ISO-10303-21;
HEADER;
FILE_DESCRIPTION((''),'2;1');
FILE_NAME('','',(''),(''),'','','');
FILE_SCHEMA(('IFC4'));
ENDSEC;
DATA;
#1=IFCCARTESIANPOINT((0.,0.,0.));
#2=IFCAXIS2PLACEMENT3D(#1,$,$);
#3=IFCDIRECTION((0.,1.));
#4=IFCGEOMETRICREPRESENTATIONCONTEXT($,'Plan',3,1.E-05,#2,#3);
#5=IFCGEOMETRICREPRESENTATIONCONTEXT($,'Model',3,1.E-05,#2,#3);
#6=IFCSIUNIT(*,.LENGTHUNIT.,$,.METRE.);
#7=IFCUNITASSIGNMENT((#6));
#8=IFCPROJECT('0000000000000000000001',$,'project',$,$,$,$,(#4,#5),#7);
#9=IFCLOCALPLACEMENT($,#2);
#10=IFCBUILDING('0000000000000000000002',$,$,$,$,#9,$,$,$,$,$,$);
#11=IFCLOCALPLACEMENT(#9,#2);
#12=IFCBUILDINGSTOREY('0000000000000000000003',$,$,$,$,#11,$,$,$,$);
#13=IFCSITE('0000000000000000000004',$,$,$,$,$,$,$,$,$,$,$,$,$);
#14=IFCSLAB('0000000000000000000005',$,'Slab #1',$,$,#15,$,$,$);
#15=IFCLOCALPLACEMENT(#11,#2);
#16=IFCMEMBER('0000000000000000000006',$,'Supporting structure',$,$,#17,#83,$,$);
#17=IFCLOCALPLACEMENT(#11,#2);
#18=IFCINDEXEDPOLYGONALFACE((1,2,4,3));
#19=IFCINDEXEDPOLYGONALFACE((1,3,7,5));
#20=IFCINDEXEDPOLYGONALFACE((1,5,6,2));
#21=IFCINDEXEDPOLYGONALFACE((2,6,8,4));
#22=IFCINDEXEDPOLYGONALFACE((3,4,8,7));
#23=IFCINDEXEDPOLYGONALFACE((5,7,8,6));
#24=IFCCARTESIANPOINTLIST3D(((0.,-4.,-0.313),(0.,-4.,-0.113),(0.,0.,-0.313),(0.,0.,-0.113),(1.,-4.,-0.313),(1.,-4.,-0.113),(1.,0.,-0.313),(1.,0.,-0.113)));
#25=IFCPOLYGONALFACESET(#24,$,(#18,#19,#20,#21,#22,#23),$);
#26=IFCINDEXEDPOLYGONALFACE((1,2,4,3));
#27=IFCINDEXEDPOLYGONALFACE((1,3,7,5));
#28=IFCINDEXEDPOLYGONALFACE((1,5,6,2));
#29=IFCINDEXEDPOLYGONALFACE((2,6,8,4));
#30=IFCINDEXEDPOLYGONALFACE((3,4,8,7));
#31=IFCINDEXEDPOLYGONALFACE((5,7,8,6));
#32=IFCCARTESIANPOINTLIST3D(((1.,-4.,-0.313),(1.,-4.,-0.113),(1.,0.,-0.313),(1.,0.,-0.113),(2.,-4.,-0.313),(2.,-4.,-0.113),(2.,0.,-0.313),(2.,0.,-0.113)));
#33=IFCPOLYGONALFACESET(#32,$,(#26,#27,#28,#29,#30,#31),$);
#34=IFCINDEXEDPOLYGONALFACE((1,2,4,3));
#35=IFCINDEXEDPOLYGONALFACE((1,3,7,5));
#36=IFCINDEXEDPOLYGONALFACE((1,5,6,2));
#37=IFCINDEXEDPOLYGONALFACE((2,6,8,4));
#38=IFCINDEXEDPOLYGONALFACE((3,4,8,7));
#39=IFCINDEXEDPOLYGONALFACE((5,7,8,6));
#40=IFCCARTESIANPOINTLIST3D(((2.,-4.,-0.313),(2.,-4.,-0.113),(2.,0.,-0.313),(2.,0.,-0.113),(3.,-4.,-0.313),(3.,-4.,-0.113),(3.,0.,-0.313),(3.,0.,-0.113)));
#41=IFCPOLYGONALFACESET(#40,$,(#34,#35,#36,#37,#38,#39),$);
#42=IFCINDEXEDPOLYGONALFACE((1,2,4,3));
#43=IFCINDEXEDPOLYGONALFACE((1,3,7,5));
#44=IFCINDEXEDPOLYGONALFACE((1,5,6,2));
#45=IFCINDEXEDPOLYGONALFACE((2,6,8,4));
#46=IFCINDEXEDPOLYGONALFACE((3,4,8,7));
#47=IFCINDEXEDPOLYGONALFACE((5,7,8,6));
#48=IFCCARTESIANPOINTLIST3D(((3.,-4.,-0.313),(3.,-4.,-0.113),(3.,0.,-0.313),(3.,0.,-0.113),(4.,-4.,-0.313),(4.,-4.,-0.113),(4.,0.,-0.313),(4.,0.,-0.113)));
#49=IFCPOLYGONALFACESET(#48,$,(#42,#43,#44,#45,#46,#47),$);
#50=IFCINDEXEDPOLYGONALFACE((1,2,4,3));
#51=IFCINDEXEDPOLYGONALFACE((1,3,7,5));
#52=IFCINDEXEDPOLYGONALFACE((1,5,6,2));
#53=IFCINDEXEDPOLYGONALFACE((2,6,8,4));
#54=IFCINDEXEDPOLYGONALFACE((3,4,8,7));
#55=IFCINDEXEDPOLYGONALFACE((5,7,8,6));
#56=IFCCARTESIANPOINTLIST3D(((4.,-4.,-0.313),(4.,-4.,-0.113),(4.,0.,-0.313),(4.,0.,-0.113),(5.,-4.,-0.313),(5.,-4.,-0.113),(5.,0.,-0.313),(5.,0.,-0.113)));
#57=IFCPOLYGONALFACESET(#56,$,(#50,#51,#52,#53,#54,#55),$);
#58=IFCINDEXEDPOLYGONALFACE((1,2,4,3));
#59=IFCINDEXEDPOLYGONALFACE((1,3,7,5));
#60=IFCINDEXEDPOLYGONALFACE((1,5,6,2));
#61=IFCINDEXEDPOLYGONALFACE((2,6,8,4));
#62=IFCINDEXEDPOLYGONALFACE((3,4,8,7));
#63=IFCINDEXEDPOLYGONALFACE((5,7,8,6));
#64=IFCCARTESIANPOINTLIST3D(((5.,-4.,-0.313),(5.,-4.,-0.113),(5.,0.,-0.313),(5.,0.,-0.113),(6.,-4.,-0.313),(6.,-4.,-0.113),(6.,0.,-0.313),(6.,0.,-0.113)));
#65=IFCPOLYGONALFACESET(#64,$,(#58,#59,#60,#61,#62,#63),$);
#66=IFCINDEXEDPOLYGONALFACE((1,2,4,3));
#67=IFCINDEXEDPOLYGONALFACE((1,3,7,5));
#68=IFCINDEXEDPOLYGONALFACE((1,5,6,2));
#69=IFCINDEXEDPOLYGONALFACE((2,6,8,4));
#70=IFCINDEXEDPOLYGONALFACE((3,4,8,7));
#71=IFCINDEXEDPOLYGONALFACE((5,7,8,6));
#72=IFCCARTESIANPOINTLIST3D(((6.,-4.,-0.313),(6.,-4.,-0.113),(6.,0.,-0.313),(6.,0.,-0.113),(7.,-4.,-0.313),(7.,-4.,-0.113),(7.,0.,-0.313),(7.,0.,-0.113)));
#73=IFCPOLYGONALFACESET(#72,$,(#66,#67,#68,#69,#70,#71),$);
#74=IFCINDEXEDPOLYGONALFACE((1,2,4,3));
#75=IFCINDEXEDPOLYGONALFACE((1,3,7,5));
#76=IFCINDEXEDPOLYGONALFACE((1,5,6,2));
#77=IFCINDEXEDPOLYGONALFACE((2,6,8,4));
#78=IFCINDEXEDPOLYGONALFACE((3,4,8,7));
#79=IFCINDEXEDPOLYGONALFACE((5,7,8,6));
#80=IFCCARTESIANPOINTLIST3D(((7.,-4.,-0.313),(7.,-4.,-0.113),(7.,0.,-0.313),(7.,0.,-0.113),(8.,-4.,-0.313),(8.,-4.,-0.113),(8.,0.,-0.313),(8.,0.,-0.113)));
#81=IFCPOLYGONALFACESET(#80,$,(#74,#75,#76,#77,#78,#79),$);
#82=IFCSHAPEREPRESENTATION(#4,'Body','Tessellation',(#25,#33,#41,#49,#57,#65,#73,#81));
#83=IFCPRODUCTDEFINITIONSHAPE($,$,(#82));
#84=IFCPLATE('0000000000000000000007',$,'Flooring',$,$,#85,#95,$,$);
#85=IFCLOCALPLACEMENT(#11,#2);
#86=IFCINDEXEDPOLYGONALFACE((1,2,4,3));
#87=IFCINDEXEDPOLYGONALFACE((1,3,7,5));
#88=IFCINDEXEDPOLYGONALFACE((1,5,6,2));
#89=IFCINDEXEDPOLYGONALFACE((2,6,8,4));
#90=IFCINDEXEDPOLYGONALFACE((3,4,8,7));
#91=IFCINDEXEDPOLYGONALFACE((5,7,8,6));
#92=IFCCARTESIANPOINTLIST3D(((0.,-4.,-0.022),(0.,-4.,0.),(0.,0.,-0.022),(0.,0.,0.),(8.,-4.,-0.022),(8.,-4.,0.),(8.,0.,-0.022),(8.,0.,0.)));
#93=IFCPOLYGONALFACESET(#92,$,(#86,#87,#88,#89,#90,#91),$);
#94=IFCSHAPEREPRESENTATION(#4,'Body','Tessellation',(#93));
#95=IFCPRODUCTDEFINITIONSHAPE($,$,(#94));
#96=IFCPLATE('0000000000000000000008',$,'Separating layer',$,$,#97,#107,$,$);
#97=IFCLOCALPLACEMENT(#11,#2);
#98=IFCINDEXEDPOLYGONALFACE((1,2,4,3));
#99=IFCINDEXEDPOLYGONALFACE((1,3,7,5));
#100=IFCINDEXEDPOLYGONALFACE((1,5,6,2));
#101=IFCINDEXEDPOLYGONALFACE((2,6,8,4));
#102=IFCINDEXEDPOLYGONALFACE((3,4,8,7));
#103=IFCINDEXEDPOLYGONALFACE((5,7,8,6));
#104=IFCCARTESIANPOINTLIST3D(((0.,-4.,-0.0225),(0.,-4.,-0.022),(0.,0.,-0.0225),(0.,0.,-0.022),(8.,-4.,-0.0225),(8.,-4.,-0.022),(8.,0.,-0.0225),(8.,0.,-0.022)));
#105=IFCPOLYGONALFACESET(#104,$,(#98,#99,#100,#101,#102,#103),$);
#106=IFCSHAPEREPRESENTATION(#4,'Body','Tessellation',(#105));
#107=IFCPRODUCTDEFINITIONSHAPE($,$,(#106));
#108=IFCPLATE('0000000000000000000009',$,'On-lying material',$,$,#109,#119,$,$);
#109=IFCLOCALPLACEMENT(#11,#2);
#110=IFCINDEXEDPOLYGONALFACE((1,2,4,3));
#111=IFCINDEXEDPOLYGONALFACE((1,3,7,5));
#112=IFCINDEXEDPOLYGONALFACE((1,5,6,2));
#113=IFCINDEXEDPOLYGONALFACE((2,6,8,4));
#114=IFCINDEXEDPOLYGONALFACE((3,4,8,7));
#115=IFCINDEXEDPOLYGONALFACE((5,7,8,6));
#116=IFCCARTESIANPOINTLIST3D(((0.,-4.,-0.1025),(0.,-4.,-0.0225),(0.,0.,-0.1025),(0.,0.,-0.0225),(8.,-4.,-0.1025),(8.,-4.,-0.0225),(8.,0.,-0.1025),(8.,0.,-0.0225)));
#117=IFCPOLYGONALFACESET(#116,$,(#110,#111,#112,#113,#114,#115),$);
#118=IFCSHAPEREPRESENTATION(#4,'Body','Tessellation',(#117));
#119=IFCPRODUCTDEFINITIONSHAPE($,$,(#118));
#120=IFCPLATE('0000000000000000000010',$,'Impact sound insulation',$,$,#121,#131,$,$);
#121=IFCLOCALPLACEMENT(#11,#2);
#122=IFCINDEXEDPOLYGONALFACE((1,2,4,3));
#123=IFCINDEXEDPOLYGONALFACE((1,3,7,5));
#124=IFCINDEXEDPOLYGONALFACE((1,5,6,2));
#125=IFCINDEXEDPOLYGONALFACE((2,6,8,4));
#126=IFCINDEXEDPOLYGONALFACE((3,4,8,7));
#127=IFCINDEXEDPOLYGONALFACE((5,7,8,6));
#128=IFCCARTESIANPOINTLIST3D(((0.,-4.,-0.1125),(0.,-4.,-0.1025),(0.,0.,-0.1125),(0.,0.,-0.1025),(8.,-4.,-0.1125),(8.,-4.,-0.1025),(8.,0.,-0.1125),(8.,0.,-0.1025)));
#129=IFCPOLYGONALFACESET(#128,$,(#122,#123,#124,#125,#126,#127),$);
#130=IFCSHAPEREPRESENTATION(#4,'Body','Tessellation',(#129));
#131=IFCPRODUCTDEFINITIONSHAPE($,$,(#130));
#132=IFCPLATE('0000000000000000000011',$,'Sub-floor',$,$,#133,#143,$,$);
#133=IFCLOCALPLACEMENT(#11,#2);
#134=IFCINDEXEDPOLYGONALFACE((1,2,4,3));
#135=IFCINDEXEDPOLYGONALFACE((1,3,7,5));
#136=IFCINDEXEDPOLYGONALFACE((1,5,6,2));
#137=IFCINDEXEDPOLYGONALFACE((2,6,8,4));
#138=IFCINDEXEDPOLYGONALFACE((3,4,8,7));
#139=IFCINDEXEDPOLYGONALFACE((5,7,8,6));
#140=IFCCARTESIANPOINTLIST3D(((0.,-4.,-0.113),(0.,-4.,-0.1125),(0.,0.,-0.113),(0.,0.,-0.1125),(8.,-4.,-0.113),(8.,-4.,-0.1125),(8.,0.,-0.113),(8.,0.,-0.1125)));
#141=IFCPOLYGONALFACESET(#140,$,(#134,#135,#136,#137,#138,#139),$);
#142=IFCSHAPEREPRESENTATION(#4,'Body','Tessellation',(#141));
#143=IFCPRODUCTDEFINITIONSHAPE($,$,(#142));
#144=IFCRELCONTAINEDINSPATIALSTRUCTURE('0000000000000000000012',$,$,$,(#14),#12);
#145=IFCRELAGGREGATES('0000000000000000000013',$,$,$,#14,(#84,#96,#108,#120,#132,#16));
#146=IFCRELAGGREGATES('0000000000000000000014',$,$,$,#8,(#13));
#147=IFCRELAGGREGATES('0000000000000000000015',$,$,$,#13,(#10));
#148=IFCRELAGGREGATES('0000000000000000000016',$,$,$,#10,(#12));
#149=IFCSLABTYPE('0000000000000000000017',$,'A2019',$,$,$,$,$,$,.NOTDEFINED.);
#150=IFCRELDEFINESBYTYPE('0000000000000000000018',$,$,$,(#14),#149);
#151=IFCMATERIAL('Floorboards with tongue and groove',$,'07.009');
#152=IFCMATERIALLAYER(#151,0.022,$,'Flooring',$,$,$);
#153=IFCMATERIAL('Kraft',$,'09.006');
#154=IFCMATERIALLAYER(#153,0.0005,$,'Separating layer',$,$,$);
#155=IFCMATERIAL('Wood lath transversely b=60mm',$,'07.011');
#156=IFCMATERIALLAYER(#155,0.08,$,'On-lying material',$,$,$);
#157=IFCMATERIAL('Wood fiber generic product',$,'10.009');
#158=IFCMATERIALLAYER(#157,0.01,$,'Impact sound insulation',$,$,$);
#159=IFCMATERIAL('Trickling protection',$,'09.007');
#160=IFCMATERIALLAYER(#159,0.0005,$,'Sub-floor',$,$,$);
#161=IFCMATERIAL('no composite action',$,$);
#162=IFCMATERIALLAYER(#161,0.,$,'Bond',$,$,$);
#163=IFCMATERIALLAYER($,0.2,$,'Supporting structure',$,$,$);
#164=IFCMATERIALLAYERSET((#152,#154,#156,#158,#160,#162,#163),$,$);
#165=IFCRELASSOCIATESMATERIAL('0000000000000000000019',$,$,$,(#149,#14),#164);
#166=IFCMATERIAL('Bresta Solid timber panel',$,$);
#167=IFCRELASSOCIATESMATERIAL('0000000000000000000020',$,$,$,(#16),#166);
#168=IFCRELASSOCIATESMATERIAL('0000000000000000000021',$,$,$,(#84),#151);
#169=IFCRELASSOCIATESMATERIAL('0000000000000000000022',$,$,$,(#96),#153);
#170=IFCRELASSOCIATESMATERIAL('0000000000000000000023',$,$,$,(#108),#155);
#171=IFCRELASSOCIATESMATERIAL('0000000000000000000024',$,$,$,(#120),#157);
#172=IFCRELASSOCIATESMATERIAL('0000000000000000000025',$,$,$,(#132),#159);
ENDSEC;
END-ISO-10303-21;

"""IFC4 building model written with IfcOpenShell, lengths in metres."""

from ifc_helpers import new_model, si_unit, direction, frame, frame_2d, origin, origin_with_axes, place, context, project, spatial, rectangle, extrude, material, layer, layer_set, type_object, element, aggregate, save


model = new_model("IFC4")

# Units and contexts
plan_context = context("Plan", 3, precision=1e-05, world=origin(), true_north=direction((0.0, 1.0)))
model_context = context("Model", 3, precision=1e-05, world=origin(), true_north=direction((0.0, 1.0)))
ifc_project = project(units=[si_unit("LENGTHUNIT", "METRE")], contexts=[plan_context, model_context])

# Site, building, storey
site = spatial("IfcSite", under=ifc_project)
building_placement = place(None, origin())
building = spatial("IfcBuilding", under=site, at=building_placement)
storey_placement = place(building_placement, origin())
storey = spatial("IfcBuildingStorey", under=building, at=storey_placement)

# Slab, member, plates
ifc_material_1 = material(Name="Floorboards with tongue and groove", Category="07.009")
ifc_layer_1 = layer(ifc_material_1, 0.022, Name="Flooring")
ifc_material_2 = material(Name="Kraft", Category="09.006")
ifc_layer_2 = layer(ifc_material_2, 0.0005, Name="Separating layer")
ifc_material_3 = material(Name="Wood lath transversely b=60mm", Category="07.011")
ifc_layer_3 = layer(ifc_material_3, 0.08, Name="On-lying material")
ifc_material_4 = material(Name="Wood fiber generic product", Category="10.009")
ifc_layer_4 = layer(ifc_material_4, 0.01, Name="Impact sound insulation")
ifc_material_5 = material(Name="Trickling protection", Category="09.007")
ifc_layer_5 = layer(ifc_material_5, 0.0005, Name="Sub-floor")
ifc_material_6 = material(Name="no composite action")
ifc_layer_6 = layer(ifc_material_6, 0.0, Name="Bond")
ifc_layer_7 = layer(None, 0.2, Name="Supporting structure")
ifc_layer_set = layer_set([ifc_layer_1, ifc_layer_2, ifc_layer_3, ifc_layer_4, ifc_layer_5, ifc_layer_6, ifc_layer_7])
slab_type = type_object("IfcSlabType", Name="A2019", PredefinedType="NOTDEFINED", material=ifc_layer_set)
slab_placement = place(None, frame((0.0, 0.0, 0.0), z_axis=(0.0, 0.0, -1.0), x_axis=(1.0, 0.0, 0.0)))
slab = element("IfcSlab", 1, at=slab_placement, inside=storey, type_object=slab_type, material=ifc_layer_set, Name="Slab #1")
ifc_material_7 = material(Name="Bresta Solid timber panel")
member_placement = place(slab_placement, origin())
member = element("IfcMember", 2, at=member_placement, material=ifc_material_7, Name="Supporting structure", context=plan_context, shape_type="SweptSolid", body=[
    extrude(rectangle(XDim=1.0, YDim=0.2, at=frame_2d((0.5, 0.1), x_axis=(1.0, 0.0))), frame((0.0, 4.0, 0.113), z_axis=(0.0, -1.0, 0.0), x_axis=(1.0, 0.0, 0.0)), (0.0, 0.0, 1.0), 4.0),
    extrude(rectangle(XDim=1.0, YDim=0.2, at=frame_2d((0.5, 0.1), x_axis=(1.0, 0.0))), frame((1.0, 4.0, 0.113), z_axis=(0.0, -1.0, 0.0), x_axis=(1.0, 0.0, 0.0)), (0.0, 0.0, 1.0), 4.0),
    extrude(rectangle(XDim=1.0, YDim=0.2, at=frame_2d((0.5, 0.1), x_axis=(1.0, 0.0))), frame((2.0, 4.0, 0.113), z_axis=(0.0, -1.0, 0.0), x_axis=(1.0, 0.0, 0.0)), (0.0, 0.0, 1.0), 4.0),
    extrude(rectangle(XDim=1.0, YDim=0.2, at=frame_2d((0.5, 0.1), x_axis=(1.0, 0.0))), frame((3.0, 4.0, 0.113), z_axis=(0.0, -1.0, 0.0), x_axis=(1.0, 0.0, 0.0)), (0.0, 0.0, 1.0), 4.0),
    extrude(rectangle(XDim=1.0, YDim=0.2, at=frame_2d((0.5, 0.1), x_axis=(1.0, 0.0))), frame((4.0, 4.0, 0.113), z_axis=(0.0, -1.0, 0.0), x_axis=(1.0, 0.0, 0.0)), (0.0, 0.0, 1.0), 4.0),
    extrude(rectangle(XDim=1.0, YDim=0.2, at=frame_2d((0.5, 0.1), x_axis=(1.0, 0.0))), frame((5.0, 4.0, 0.113), z_axis=(0.0, -1.0, 0.0), x_axis=(1.0, 0.0, 0.0)), (0.0, 0.0, 1.0), 4.0),
    extrude(rectangle(XDim=1.0, YDim=0.2, at=frame_2d((0.5, 0.1), x_axis=(1.0, 0.0))), frame((6.0, 4.0, 0.113), z_axis=(0.0, -1.0, 0.0), x_axis=(1.0, 0.0, 0.0)), (0.0, 0.0, 1.0), 4.0),
    extrude(rectangle(XDim=1.0, YDim=0.2, at=frame_2d((0.5, 0.1), x_axis=(1.0, 0.0))), frame((7.0, 4.0, 0.113), z_axis=(0.0, -1.0, 0.0), x_axis=(1.0, 0.0, 0.0)), (0.0, 0.0, 1.0), 4.0),
])
plate_1_placement = place(slab_placement, origin())
plate_1 = element("IfcPlate", 3, at=plate_1_placement, material=ifc_material_1, Name="Flooring", context=plan_context, shape_type="SweptSolid", body=[
    extrude(rectangle(XDim=8.0, YDim=4.0, at=frame_2d((4.0, 2.0), x_axis=(1.0, 0.0))), origin_with_axes(), (0.0, 0.0, 1.0), 0.022),
])
plate_2_placement = place(slab_placement, origin())
plate_2 = element("IfcPlate", 4, at=plate_2_placement, material=ifc_material_2, Name="Separating layer", context=plan_context, shape_type="SweptSolid", body=[
    extrude(rectangle(XDim=8.0, YDim=4.0, at=frame_2d((4.0, 2.0), x_axis=(1.0, 0.0))), frame((0.0, 0.0, 0.022), z_axis=(0.0, 0.0, 1.0), x_axis=(1.0, 0.0, 0.0)), (0.0, 0.0, 1.0), 0.0005),
])
plate_3_placement = place(slab_placement, origin())
plate_3 = element("IfcPlate", 5, at=plate_3_placement, material=ifc_material_3, Name="On-lying material", context=plan_context, shape_type="SweptSolid", body=[
    extrude(rectangle(XDim=8.0, YDim=4.0, at=frame_2d((4.0, 2.0), x_axis=(1.0, 0.0))), frame((0.0, 0.0, 0.0225), z_axis=(0.0, 0.0, 1.0), x_axis=(1.0, 0.0, 0.0)), (0.0, 0.0, 1.0), 0.08),
])
plate_4_placement = place(slab_placement, origin())
plate_4 = element("IfcPlate", 6, at=plate_4_placement, material=ifc_material_4, Name="Impact sound insulation", context=plan_context, shape_type="SweptSolid", body=[
    extrude(rectangle(XDim=8.0, YDim=4.0, at=frame_2d((4.0, 2.0), x_axis=(1.0, 0.0))), frame((0.0, 0.0, 0.1025), z_axis=(0.0, 0.0, 1.0), x_axis=(1.0, 0.0, 0.0)), (0.0, 0.0, 1.0), 0.01),
])
plate_5_placement = place(slab_placement, origin())
plate_5 = element("IfcPlate", 7, at=plate_5_placement, material=ifc_material_5, Name="Sub-floor", context=plan_context, shape_type="SweptSolid", body=[
    extrude(rectangle(XDim=8.0, YDim=4.0, at=frame_2d((4.0, 2.0), x_axis=(1.0, 0.0))), frame((0.0, 0.0, 0.1125), z_axis=(0.0, 0.0, 1.0), x_axis=(1.0, 0.0, 0.0)), (0.0, 0.0, 1.0), 0.0005),
])
aggregate(slab, [plate_1, plate_2, plate_3, plate_4, plate_5, member])

save(model, "model.ifc")
